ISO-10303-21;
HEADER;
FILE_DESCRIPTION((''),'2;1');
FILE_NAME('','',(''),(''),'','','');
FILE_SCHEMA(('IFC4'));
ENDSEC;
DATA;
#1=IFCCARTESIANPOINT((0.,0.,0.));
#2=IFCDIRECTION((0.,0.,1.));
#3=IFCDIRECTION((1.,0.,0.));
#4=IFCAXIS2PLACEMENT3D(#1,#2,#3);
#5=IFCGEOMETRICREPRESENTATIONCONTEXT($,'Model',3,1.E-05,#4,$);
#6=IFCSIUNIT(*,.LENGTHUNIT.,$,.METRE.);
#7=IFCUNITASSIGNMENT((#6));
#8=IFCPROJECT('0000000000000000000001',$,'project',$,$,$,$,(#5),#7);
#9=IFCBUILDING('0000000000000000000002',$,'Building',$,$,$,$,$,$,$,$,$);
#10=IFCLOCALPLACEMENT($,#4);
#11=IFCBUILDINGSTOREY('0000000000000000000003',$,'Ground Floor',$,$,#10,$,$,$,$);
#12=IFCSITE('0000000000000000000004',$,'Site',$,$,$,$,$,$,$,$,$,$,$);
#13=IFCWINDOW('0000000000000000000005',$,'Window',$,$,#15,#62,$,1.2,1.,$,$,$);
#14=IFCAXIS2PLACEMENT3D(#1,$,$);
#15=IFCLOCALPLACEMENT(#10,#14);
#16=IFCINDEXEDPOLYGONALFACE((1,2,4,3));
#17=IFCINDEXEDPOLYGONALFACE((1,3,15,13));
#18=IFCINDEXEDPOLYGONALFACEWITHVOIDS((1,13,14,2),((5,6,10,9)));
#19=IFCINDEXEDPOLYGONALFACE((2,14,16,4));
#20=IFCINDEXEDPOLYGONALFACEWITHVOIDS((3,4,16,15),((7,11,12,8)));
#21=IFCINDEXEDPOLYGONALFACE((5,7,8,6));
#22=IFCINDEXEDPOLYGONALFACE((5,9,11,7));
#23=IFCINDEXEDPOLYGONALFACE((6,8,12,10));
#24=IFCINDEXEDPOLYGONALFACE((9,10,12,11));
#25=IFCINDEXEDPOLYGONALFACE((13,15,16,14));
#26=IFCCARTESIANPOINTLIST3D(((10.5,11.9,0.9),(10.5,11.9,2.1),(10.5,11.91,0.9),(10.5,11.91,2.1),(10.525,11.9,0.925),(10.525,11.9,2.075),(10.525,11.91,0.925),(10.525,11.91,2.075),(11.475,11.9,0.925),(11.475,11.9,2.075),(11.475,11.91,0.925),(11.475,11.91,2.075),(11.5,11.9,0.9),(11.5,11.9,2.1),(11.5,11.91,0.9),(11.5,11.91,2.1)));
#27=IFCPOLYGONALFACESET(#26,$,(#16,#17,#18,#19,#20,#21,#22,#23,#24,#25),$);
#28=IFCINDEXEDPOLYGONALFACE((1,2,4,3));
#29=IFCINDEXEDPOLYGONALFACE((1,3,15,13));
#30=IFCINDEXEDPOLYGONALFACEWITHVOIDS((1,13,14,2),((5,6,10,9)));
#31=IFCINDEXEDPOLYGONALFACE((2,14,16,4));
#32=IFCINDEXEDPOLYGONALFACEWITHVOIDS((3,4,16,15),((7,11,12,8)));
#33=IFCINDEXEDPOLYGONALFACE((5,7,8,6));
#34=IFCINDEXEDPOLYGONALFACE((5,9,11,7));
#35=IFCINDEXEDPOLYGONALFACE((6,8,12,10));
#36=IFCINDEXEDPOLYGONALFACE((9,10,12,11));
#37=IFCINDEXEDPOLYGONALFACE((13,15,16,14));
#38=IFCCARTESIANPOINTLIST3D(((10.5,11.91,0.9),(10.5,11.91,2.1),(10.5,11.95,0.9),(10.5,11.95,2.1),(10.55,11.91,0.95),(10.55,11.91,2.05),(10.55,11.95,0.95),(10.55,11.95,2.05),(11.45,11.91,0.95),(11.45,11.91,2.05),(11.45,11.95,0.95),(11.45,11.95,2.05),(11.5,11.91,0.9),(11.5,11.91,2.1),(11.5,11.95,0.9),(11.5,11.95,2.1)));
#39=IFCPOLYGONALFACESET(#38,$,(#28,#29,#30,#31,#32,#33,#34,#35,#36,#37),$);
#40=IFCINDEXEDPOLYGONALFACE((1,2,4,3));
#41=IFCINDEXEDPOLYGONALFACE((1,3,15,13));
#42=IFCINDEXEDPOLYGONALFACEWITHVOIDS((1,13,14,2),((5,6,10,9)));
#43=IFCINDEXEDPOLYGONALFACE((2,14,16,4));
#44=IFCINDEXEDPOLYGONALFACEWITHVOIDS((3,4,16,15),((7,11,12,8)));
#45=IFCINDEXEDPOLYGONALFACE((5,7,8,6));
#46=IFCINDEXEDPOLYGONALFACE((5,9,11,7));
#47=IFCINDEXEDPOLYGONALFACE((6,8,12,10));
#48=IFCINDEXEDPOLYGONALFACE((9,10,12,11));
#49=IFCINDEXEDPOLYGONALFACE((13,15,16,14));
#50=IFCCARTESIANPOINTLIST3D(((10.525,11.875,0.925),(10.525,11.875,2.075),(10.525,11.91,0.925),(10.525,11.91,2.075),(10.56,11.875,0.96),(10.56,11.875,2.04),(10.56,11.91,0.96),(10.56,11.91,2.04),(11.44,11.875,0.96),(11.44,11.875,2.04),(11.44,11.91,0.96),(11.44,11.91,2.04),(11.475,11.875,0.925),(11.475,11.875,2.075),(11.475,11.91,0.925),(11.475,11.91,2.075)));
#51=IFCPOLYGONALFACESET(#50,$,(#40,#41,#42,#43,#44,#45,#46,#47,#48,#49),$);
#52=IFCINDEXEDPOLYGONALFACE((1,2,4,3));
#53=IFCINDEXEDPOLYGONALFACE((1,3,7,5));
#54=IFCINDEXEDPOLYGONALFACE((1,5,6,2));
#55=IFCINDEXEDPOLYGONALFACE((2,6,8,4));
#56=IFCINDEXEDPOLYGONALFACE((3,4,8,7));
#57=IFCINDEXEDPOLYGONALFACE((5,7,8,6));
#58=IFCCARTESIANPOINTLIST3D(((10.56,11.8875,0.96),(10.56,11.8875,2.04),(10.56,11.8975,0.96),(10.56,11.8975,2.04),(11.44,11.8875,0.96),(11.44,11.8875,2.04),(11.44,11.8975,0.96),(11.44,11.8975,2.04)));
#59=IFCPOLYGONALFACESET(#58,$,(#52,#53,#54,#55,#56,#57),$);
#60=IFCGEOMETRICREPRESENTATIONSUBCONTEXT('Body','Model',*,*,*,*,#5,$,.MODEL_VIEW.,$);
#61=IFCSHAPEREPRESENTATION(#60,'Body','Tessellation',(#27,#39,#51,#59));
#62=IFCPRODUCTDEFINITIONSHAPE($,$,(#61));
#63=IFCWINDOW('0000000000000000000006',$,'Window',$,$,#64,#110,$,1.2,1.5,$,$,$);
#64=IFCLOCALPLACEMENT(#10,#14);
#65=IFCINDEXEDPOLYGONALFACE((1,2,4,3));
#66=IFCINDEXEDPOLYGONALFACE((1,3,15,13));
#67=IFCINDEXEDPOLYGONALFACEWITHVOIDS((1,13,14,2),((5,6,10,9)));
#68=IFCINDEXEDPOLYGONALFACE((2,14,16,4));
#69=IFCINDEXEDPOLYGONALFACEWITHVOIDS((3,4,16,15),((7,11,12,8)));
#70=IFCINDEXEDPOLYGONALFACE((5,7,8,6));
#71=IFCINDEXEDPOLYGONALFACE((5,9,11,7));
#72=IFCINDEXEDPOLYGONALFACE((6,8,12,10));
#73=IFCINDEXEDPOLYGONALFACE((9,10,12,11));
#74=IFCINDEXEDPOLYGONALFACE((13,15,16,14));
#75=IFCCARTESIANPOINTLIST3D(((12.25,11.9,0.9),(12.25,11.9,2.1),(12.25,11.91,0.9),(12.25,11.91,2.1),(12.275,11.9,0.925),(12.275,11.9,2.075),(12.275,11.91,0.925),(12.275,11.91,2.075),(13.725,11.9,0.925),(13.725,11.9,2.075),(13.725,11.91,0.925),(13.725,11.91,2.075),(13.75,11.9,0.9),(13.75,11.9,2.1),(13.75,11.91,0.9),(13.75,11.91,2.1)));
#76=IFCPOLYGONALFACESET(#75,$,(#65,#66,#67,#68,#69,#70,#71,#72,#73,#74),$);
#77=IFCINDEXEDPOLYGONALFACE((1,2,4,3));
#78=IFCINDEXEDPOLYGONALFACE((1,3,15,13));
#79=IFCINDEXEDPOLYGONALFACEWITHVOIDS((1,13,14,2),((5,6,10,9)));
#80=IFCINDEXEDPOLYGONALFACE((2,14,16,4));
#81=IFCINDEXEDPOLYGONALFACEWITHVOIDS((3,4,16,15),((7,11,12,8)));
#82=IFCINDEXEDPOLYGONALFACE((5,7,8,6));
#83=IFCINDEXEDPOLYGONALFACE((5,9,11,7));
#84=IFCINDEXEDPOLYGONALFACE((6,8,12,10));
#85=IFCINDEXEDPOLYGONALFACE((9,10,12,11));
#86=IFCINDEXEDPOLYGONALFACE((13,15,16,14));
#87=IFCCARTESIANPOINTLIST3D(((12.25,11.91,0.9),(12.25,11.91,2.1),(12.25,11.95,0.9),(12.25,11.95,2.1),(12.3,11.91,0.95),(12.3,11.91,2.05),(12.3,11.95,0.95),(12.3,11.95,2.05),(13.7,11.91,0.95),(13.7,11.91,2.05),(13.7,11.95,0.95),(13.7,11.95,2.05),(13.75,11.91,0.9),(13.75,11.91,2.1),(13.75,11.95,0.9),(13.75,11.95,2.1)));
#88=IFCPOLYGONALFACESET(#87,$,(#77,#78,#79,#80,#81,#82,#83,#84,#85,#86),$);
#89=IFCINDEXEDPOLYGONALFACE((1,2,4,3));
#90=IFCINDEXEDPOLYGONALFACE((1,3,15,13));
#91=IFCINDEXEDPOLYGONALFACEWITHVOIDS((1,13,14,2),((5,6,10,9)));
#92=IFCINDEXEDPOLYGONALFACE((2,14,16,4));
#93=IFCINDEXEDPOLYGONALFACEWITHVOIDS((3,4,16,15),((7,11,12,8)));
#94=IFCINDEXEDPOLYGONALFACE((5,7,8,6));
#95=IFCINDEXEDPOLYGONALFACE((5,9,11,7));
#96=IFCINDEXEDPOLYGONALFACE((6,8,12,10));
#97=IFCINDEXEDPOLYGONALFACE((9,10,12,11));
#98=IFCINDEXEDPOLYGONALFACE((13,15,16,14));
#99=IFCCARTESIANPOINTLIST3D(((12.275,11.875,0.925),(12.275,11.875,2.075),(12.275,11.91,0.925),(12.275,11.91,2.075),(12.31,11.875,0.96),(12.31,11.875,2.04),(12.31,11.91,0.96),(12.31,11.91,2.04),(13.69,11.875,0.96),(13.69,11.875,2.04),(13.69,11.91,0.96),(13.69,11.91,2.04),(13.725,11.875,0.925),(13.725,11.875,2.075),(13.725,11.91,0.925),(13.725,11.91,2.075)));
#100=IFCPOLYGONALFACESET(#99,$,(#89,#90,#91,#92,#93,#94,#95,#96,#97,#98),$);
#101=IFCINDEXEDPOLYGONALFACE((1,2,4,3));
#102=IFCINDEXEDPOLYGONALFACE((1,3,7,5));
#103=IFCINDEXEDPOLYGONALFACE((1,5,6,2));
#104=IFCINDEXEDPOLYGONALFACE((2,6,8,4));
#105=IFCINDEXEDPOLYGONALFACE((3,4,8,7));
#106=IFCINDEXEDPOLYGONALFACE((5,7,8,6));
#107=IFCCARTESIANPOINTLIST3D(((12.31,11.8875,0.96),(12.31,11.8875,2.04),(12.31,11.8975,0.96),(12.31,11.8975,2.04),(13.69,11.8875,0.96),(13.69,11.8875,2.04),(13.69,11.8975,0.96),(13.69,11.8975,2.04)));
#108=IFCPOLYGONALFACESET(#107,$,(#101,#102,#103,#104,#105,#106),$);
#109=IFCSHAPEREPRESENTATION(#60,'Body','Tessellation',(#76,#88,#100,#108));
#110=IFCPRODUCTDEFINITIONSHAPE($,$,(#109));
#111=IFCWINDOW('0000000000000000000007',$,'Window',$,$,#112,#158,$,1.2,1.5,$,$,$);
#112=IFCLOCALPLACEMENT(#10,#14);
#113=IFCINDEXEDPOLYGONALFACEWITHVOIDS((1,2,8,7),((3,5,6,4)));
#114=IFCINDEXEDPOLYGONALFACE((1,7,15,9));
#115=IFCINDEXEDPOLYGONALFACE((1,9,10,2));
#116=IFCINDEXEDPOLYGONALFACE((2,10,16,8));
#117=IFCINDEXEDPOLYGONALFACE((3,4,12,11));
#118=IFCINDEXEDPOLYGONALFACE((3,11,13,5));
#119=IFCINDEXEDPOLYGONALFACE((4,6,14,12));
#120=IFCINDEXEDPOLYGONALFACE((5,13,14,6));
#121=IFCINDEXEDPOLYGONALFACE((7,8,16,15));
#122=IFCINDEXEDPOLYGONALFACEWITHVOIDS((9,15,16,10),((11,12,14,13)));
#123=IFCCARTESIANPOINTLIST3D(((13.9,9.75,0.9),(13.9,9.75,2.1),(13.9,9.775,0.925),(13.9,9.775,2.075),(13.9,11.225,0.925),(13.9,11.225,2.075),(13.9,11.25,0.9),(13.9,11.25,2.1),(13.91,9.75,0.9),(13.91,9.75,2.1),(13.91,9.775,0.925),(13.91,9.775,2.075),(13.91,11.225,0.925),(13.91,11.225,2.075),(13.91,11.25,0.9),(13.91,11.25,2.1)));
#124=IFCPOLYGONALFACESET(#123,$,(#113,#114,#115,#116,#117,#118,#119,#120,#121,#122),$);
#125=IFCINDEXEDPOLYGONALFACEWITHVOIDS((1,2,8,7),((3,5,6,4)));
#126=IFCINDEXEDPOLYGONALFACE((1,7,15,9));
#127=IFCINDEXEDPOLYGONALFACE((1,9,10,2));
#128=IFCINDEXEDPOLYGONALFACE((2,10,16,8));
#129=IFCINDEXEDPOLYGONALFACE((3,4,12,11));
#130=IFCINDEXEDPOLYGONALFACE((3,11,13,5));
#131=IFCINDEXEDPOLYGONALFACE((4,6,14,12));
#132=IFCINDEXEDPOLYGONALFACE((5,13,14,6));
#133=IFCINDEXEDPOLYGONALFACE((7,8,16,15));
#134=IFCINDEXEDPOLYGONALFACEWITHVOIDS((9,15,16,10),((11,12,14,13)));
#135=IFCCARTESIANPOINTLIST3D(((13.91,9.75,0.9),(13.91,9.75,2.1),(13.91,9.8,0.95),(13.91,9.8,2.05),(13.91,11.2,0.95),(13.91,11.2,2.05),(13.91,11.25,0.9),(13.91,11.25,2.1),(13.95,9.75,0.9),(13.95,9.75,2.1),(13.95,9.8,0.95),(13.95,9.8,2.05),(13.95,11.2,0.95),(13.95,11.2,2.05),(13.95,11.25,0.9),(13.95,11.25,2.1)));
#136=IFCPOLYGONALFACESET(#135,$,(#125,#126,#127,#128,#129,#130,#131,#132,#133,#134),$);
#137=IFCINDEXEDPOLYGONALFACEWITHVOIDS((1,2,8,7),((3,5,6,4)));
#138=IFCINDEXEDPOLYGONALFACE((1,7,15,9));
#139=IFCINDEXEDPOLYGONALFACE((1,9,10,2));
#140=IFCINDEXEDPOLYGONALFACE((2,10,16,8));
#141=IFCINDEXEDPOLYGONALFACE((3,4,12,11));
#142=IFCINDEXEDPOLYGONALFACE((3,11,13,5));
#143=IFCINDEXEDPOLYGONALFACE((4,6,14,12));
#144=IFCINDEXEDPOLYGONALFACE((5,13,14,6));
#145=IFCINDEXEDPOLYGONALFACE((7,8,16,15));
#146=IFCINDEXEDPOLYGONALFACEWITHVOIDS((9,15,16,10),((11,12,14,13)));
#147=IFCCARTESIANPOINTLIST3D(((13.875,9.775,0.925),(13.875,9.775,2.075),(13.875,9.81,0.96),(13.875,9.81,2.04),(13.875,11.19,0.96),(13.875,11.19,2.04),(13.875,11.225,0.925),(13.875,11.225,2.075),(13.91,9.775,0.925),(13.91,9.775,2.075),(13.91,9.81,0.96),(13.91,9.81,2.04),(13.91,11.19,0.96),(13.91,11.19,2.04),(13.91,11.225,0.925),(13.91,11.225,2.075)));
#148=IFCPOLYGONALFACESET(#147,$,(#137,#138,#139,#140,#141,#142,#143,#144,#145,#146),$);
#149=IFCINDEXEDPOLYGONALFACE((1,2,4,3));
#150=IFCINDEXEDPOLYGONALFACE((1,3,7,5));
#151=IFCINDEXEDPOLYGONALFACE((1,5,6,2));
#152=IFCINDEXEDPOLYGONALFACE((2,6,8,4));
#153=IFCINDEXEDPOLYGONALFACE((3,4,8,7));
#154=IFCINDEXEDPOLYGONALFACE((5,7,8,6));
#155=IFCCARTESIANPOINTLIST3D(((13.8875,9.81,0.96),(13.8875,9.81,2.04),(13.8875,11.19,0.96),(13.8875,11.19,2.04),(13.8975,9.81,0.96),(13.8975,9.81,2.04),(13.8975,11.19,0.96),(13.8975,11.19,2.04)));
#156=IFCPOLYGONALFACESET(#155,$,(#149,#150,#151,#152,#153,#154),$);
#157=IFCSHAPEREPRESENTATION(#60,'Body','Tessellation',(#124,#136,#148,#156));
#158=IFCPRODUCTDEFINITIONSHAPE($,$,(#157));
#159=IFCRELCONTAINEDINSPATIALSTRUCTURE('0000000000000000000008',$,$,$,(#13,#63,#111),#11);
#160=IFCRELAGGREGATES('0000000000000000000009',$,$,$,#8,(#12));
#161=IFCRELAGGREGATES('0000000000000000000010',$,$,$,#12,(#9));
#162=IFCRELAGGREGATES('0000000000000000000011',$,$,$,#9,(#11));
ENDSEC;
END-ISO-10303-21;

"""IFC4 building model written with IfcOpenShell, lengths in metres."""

from ifc_helpers import new_model, si_unit, frame, origin_with_axes, place, context, subcontext, project, spatial, line, indexed_curve, outline, extrude, element, save


model = new_model("IFC4")

# Units and contexts
model_context = context("Model", 3, precision=1e-05, world=origin_with_axes())
body_context = subcontext(model_context, "Body", "Model", "MODEL_VIEW")
ifc_project = project(units=[si_unit("LENGTHUNIT", "METRE")], contexts=[model_context])

# Site, building, storey
site = spatial("IfcSite", under=ifc_project, Name="Site")
building = spatial("IfcBuilding", under=site, Name="Building")
storey_placement = place(None, origin_with_axes())
storey = spatial("IfcBuildingStorey", under=building, at=storey_placement, Name="Ground Floor")

# Windows
window_1_placement = place(storey_placement, frame((11.5, 12.0, 0.9), z_axis=(0.0, 0.0, 1.0), x_axis=(-1.0, 0.0, 0.0)))
element("IfcWindow", 1, at=window_1_placement, inside=storey, Name="Window", OverallHeight=1.2, OverallWidth=1.0, context=body_context, shape_type="SweptSolid", body=[
    extrude(outline(indexed_curve([(0.0, 0.0), (1.0, 0.0), (1.0, 1.2), (0.0, 1.2)], segments=[line(1, 2, 3, 4, 1)]), holes=[indexed_curve([(0.025, 0.025), (0.975, 0.025), (0.975, 1.175), (0.025, 1.175)], segments=[line(1, 2, 3, 4, 1)])]), frame((0.0, 0.09, 0.0), z_axis=(0.0, -1.0, 0.0), x_axis=(1.0, 0.0, 0.0)), (0.0, 0.0, -1.0), 0.01),
    extrude(outline(indexed_curve([(0.0, 0.0), (1.0, 0.0), (1.0, 1.2), (0.0, 1.2)], segments=[line(1, 2, 3, 4, 1)]), holes=[indexed_curve([(0.05, 0.05), (0.95, 0.05), (0.95, 1.15), (0.05, 1.15)], segments=[line(1, 2, 3, 4, 1)])]), frame((0.0, 0.05, 0.0), z_axis=(0.0, -1.0, 0.0), x_axis=(1.0, 0.0, 0.0)), (0.0, 0.0, -1.0), 0.04),
    extrude(outline(indexed_curve([(0.0, 0.0), (0.95, 0.0), (0.95, 1.15), (0.0, 1.15)], segments=[line(1, 2, 3, 4, 1)]), holes=[indexed_curve([(0.035, 0.035), (0.915, 0.035), (0.915, 1.115), (0.035, 1.115)], segments=[line(1, 2, 3, 4, 1)])]), frame((0.025, 0.09, 0.025), z_axis=(0.0, -1.0, 0.0), x_axis=(1.0, 0.0, 0.0)), (0.0, 0.0, -1.0), 0.035),
    extrude(outline(indexed_curve([(0.035, 0.035), (0.915, 0.035), (0.915, 1.115), (0.035, 1.115)], segments=[line(1, 2, 3, 4, 1)])), frame((0.025, 0.1025, 0.025), z_axis=(0.0, -1.0, 0.0), x_axis=(1.0, 0.0, 0.0)), (0.0, 0.0, -1.0), 0.01),
])
for number, where, z_axis, x_axis, name in (
    (2, (13.75, 12.0, 0.9), (0.0, 0.0, 1.0), (-1.0, 0.0, 0.0), "Window"),
    (3, (14.0, 9.75, 0.9), (0.0, 0.0, 1.0), (0.0, 1.0, 0.0), "Window"),
):
    element("IfcWindow", number, at=place(storey_placement, frame(where, z_axis=z_axis, x_axis=x_axis)), inside=storey, Name=name, OverallHeight=1.2, OverallWidth=1.5, context=body_context, shape_type="SweptSolid", body=[
        extrude(outline(indexed_curve([(0.0, 0.0), (1.5, 0.0), (1.5, 1.2), (0.0, 1.2)], segments=[line(1, 2, 3, 4, 1)]), holes=[indexed_curve([(0.025, 0.025), (1.475, 0.025), (1.475, 1.175), (0.025, 1.175)], segments=[line(1, 2, 3, 4, 1)])]), frame((0.0, 0.09, 0.0), z_axis=(0.0, -1.0, 0.0), x_axis=(1.0, 0.0, 0.0)), (0.0, 0.0, -1.0), 0.01),
        extrude(outline(indexed_curve([(0.0, 0.0), (1.5, 0.0), (1.5, 1.2), (0.0, 1.2)], segments=[line(1, 2, 3, 4, 1)]), holes=[indexed_curve([(0.05, 0.05), (1.45, 0.05), (1.45, 1.15), (0.05, 1.15)], segments=[line(1, 2, 3, 4, 1)])]), frame((0.0, 0.05, 0.0), z_axis=(0.0, -1.0, 0.0), x_axis=(1.0, 0.0, 0.0)), (0.0, 0.0, -1.0), 0.04),
        extrude(outline(indexed_curve([(0.0, 0.0), (1.45, 0.0), (1.45, 1.15), (0.0, 1.15)], segments=[line(1, 2, 3, 4, 1)]), holes=[indexed_curve([(0.035, 0.035), (1.415, 0.035), (1.415, 1.115), (0.035, 1.115)], segments=[line(1, 2, 3, 4, 1)])]), frame((0.025, 0.09, 0.025), z_axis=(0.0, -1.0, 0.0), x_axis=(1.0, 0.0, 0.0)), (0.0, 0.0, -1.0), 0.035),
        extrude(outline(indexed_curve([(0.035, 0.035), (1.415, 0.035), (1.415, 1.115), (0.035, 1.115)], segments=[line(1, 2, 3, 4, 1)])), frame((0.025, 0.1025, 0.025), z_axis=(0.0, -1.0, 0.0), x_axis=(1.0, 0.0, 0.0)), (0.0, 0.0, -1.0), 0.01),
    ])

save(model, "model.ifc")
